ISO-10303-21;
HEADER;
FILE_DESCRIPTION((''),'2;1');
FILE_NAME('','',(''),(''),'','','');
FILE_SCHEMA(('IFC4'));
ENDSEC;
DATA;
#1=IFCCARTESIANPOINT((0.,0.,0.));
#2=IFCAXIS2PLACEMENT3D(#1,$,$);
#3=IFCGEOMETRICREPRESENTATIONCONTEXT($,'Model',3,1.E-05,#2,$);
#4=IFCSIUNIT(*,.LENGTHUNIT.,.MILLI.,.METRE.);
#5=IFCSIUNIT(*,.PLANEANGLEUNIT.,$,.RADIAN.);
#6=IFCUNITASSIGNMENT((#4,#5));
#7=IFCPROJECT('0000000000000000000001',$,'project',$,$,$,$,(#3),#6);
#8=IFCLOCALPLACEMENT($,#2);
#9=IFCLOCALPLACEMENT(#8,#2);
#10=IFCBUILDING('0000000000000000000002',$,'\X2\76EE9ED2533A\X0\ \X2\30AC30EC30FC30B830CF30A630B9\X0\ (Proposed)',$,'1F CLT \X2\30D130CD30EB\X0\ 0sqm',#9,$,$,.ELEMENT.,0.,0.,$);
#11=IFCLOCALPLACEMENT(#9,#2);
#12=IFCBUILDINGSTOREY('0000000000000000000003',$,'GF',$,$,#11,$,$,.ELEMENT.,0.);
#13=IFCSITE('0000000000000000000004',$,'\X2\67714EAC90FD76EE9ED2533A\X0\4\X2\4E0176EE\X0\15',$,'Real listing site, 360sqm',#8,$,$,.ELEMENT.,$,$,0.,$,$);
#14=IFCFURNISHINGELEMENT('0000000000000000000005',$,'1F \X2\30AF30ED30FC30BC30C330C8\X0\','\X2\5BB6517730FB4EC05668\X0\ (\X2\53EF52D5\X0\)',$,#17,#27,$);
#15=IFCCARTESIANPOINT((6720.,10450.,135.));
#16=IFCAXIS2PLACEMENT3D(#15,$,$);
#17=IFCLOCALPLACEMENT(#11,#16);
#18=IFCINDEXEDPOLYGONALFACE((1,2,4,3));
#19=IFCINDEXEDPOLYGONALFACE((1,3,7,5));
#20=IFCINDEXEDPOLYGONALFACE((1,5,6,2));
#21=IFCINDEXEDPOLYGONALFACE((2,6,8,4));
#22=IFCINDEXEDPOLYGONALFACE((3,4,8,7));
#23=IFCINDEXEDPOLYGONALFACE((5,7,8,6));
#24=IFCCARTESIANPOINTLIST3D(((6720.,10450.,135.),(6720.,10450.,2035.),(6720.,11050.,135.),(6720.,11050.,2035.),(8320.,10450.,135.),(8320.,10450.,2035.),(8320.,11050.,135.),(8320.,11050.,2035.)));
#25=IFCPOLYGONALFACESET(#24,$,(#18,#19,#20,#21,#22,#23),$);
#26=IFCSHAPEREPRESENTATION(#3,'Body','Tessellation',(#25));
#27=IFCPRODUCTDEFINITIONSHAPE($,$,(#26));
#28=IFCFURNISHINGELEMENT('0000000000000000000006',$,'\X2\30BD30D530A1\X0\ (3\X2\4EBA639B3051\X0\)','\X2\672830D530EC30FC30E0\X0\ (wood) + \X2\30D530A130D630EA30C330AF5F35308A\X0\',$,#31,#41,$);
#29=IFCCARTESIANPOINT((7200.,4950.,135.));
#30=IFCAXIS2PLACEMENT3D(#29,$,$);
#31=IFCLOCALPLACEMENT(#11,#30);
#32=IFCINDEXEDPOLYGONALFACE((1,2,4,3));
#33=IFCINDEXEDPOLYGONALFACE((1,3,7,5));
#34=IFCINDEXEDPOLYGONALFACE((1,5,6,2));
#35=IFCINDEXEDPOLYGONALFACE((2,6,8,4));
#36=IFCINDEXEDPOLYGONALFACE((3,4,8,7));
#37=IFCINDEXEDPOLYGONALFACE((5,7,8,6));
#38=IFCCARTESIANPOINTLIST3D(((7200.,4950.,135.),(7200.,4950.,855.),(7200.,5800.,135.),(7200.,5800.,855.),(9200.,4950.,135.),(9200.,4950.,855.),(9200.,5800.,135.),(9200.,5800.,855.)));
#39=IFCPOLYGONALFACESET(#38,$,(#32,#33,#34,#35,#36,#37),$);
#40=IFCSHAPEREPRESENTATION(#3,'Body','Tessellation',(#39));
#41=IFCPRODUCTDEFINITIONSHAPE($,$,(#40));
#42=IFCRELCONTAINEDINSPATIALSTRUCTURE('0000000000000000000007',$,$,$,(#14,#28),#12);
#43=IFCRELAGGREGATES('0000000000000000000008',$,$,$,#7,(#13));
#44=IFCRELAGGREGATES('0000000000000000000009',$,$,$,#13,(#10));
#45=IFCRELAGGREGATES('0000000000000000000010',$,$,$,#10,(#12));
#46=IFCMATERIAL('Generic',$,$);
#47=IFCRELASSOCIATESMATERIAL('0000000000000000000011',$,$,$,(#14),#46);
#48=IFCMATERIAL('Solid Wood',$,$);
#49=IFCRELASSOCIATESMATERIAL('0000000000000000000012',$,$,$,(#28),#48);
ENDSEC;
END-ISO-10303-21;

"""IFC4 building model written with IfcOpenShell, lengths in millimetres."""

from ifc_helpers import new_model, si_unit, frame, frame_2d, origin, place, context, project, spatial, rectangle, extrude, material, element, save


model = new_model("IFC4")

# Units and contexts
model_context = context("Model", 3, precision=1e-05, world=origin())
ifc_project = project(units=[si_unit("LENGTHUNIT", "METRE", prefix="MILLI"), si_unit("PLANEANGLEUNIT", "RADIAN")], contexts=[model_context])

# Site, building, storey
site_placement = place(None, origin())
site = spatial("IfcSite", under=ifc_project, at=site_placement, Name="東京都目黒区4丁目15", ObjectType="Real listing site, 360sqm", CompositionType="ELEMENT", RefElevation=0.0)
building_placement = place(site_placement, origin())
building = spatial("IfcBuilding", under=site, at=building_placement, Name="目黒区 ガレージハウス (Proposed)", ObjectType="1F CLT パネル 0sqm", CompositionType="ELEMENT", ElevationOfRefHeight=0.0, ElevationOfTerrain=0.0)
storey_placement = place(building_placement, origin())
storey = spatial("IfcBuildingStorey", under=building, at=storey_placement, Name="GF", CompositionType="ELEMENT", Elevation=0.0)

# Shared definitions
ifc_material_1 = material(Name="Solid Wood")

# Shared definitions
ifc_material_2 = material(Name="Generic")

# Furnishing elements
furnishing_1_placement = place(storey_placement, frame((6720.0, 10450.0, 135.0)))
element("IfcFurnishingElement", 1, at=furnishing_1_placement, inside=storey, material=ifc_material_2, Name="1F クローゼット", Description="家具・什器 (可動)", context=model_context, shape_type="SweptSolid", body=[
    extrude(rectangle(XDim=1600.0, YDim=600.0, at=frame_2d((800.0, 300.0))), frame((6720.0, 10450.0, 135.0)), (0.0, 0.0, 1.0), 1900.0),
])
furnishing_2_placement = place(storey_placement, frame((7200.0, 4950.0, 135.0)))
element("IfcFurnishingElement", 2, at=furnishing_2_placement, inside=storey, material=ifc_material_1, Name="ソファ (3人掛け)", Description="木フレーム (wood) + ファブリック張り", context=model_context, shape_type="SweptSolid", body=[
    extrude(rectangle(XDim=2000.0, YDim=850.0, at=frame_2d((1000.0, 425.0))), frame((7200.0, 4950.0, 135.0)), (0.0, 0.0, 1.0), 720.0),
])

save(model, "model.ifc")
